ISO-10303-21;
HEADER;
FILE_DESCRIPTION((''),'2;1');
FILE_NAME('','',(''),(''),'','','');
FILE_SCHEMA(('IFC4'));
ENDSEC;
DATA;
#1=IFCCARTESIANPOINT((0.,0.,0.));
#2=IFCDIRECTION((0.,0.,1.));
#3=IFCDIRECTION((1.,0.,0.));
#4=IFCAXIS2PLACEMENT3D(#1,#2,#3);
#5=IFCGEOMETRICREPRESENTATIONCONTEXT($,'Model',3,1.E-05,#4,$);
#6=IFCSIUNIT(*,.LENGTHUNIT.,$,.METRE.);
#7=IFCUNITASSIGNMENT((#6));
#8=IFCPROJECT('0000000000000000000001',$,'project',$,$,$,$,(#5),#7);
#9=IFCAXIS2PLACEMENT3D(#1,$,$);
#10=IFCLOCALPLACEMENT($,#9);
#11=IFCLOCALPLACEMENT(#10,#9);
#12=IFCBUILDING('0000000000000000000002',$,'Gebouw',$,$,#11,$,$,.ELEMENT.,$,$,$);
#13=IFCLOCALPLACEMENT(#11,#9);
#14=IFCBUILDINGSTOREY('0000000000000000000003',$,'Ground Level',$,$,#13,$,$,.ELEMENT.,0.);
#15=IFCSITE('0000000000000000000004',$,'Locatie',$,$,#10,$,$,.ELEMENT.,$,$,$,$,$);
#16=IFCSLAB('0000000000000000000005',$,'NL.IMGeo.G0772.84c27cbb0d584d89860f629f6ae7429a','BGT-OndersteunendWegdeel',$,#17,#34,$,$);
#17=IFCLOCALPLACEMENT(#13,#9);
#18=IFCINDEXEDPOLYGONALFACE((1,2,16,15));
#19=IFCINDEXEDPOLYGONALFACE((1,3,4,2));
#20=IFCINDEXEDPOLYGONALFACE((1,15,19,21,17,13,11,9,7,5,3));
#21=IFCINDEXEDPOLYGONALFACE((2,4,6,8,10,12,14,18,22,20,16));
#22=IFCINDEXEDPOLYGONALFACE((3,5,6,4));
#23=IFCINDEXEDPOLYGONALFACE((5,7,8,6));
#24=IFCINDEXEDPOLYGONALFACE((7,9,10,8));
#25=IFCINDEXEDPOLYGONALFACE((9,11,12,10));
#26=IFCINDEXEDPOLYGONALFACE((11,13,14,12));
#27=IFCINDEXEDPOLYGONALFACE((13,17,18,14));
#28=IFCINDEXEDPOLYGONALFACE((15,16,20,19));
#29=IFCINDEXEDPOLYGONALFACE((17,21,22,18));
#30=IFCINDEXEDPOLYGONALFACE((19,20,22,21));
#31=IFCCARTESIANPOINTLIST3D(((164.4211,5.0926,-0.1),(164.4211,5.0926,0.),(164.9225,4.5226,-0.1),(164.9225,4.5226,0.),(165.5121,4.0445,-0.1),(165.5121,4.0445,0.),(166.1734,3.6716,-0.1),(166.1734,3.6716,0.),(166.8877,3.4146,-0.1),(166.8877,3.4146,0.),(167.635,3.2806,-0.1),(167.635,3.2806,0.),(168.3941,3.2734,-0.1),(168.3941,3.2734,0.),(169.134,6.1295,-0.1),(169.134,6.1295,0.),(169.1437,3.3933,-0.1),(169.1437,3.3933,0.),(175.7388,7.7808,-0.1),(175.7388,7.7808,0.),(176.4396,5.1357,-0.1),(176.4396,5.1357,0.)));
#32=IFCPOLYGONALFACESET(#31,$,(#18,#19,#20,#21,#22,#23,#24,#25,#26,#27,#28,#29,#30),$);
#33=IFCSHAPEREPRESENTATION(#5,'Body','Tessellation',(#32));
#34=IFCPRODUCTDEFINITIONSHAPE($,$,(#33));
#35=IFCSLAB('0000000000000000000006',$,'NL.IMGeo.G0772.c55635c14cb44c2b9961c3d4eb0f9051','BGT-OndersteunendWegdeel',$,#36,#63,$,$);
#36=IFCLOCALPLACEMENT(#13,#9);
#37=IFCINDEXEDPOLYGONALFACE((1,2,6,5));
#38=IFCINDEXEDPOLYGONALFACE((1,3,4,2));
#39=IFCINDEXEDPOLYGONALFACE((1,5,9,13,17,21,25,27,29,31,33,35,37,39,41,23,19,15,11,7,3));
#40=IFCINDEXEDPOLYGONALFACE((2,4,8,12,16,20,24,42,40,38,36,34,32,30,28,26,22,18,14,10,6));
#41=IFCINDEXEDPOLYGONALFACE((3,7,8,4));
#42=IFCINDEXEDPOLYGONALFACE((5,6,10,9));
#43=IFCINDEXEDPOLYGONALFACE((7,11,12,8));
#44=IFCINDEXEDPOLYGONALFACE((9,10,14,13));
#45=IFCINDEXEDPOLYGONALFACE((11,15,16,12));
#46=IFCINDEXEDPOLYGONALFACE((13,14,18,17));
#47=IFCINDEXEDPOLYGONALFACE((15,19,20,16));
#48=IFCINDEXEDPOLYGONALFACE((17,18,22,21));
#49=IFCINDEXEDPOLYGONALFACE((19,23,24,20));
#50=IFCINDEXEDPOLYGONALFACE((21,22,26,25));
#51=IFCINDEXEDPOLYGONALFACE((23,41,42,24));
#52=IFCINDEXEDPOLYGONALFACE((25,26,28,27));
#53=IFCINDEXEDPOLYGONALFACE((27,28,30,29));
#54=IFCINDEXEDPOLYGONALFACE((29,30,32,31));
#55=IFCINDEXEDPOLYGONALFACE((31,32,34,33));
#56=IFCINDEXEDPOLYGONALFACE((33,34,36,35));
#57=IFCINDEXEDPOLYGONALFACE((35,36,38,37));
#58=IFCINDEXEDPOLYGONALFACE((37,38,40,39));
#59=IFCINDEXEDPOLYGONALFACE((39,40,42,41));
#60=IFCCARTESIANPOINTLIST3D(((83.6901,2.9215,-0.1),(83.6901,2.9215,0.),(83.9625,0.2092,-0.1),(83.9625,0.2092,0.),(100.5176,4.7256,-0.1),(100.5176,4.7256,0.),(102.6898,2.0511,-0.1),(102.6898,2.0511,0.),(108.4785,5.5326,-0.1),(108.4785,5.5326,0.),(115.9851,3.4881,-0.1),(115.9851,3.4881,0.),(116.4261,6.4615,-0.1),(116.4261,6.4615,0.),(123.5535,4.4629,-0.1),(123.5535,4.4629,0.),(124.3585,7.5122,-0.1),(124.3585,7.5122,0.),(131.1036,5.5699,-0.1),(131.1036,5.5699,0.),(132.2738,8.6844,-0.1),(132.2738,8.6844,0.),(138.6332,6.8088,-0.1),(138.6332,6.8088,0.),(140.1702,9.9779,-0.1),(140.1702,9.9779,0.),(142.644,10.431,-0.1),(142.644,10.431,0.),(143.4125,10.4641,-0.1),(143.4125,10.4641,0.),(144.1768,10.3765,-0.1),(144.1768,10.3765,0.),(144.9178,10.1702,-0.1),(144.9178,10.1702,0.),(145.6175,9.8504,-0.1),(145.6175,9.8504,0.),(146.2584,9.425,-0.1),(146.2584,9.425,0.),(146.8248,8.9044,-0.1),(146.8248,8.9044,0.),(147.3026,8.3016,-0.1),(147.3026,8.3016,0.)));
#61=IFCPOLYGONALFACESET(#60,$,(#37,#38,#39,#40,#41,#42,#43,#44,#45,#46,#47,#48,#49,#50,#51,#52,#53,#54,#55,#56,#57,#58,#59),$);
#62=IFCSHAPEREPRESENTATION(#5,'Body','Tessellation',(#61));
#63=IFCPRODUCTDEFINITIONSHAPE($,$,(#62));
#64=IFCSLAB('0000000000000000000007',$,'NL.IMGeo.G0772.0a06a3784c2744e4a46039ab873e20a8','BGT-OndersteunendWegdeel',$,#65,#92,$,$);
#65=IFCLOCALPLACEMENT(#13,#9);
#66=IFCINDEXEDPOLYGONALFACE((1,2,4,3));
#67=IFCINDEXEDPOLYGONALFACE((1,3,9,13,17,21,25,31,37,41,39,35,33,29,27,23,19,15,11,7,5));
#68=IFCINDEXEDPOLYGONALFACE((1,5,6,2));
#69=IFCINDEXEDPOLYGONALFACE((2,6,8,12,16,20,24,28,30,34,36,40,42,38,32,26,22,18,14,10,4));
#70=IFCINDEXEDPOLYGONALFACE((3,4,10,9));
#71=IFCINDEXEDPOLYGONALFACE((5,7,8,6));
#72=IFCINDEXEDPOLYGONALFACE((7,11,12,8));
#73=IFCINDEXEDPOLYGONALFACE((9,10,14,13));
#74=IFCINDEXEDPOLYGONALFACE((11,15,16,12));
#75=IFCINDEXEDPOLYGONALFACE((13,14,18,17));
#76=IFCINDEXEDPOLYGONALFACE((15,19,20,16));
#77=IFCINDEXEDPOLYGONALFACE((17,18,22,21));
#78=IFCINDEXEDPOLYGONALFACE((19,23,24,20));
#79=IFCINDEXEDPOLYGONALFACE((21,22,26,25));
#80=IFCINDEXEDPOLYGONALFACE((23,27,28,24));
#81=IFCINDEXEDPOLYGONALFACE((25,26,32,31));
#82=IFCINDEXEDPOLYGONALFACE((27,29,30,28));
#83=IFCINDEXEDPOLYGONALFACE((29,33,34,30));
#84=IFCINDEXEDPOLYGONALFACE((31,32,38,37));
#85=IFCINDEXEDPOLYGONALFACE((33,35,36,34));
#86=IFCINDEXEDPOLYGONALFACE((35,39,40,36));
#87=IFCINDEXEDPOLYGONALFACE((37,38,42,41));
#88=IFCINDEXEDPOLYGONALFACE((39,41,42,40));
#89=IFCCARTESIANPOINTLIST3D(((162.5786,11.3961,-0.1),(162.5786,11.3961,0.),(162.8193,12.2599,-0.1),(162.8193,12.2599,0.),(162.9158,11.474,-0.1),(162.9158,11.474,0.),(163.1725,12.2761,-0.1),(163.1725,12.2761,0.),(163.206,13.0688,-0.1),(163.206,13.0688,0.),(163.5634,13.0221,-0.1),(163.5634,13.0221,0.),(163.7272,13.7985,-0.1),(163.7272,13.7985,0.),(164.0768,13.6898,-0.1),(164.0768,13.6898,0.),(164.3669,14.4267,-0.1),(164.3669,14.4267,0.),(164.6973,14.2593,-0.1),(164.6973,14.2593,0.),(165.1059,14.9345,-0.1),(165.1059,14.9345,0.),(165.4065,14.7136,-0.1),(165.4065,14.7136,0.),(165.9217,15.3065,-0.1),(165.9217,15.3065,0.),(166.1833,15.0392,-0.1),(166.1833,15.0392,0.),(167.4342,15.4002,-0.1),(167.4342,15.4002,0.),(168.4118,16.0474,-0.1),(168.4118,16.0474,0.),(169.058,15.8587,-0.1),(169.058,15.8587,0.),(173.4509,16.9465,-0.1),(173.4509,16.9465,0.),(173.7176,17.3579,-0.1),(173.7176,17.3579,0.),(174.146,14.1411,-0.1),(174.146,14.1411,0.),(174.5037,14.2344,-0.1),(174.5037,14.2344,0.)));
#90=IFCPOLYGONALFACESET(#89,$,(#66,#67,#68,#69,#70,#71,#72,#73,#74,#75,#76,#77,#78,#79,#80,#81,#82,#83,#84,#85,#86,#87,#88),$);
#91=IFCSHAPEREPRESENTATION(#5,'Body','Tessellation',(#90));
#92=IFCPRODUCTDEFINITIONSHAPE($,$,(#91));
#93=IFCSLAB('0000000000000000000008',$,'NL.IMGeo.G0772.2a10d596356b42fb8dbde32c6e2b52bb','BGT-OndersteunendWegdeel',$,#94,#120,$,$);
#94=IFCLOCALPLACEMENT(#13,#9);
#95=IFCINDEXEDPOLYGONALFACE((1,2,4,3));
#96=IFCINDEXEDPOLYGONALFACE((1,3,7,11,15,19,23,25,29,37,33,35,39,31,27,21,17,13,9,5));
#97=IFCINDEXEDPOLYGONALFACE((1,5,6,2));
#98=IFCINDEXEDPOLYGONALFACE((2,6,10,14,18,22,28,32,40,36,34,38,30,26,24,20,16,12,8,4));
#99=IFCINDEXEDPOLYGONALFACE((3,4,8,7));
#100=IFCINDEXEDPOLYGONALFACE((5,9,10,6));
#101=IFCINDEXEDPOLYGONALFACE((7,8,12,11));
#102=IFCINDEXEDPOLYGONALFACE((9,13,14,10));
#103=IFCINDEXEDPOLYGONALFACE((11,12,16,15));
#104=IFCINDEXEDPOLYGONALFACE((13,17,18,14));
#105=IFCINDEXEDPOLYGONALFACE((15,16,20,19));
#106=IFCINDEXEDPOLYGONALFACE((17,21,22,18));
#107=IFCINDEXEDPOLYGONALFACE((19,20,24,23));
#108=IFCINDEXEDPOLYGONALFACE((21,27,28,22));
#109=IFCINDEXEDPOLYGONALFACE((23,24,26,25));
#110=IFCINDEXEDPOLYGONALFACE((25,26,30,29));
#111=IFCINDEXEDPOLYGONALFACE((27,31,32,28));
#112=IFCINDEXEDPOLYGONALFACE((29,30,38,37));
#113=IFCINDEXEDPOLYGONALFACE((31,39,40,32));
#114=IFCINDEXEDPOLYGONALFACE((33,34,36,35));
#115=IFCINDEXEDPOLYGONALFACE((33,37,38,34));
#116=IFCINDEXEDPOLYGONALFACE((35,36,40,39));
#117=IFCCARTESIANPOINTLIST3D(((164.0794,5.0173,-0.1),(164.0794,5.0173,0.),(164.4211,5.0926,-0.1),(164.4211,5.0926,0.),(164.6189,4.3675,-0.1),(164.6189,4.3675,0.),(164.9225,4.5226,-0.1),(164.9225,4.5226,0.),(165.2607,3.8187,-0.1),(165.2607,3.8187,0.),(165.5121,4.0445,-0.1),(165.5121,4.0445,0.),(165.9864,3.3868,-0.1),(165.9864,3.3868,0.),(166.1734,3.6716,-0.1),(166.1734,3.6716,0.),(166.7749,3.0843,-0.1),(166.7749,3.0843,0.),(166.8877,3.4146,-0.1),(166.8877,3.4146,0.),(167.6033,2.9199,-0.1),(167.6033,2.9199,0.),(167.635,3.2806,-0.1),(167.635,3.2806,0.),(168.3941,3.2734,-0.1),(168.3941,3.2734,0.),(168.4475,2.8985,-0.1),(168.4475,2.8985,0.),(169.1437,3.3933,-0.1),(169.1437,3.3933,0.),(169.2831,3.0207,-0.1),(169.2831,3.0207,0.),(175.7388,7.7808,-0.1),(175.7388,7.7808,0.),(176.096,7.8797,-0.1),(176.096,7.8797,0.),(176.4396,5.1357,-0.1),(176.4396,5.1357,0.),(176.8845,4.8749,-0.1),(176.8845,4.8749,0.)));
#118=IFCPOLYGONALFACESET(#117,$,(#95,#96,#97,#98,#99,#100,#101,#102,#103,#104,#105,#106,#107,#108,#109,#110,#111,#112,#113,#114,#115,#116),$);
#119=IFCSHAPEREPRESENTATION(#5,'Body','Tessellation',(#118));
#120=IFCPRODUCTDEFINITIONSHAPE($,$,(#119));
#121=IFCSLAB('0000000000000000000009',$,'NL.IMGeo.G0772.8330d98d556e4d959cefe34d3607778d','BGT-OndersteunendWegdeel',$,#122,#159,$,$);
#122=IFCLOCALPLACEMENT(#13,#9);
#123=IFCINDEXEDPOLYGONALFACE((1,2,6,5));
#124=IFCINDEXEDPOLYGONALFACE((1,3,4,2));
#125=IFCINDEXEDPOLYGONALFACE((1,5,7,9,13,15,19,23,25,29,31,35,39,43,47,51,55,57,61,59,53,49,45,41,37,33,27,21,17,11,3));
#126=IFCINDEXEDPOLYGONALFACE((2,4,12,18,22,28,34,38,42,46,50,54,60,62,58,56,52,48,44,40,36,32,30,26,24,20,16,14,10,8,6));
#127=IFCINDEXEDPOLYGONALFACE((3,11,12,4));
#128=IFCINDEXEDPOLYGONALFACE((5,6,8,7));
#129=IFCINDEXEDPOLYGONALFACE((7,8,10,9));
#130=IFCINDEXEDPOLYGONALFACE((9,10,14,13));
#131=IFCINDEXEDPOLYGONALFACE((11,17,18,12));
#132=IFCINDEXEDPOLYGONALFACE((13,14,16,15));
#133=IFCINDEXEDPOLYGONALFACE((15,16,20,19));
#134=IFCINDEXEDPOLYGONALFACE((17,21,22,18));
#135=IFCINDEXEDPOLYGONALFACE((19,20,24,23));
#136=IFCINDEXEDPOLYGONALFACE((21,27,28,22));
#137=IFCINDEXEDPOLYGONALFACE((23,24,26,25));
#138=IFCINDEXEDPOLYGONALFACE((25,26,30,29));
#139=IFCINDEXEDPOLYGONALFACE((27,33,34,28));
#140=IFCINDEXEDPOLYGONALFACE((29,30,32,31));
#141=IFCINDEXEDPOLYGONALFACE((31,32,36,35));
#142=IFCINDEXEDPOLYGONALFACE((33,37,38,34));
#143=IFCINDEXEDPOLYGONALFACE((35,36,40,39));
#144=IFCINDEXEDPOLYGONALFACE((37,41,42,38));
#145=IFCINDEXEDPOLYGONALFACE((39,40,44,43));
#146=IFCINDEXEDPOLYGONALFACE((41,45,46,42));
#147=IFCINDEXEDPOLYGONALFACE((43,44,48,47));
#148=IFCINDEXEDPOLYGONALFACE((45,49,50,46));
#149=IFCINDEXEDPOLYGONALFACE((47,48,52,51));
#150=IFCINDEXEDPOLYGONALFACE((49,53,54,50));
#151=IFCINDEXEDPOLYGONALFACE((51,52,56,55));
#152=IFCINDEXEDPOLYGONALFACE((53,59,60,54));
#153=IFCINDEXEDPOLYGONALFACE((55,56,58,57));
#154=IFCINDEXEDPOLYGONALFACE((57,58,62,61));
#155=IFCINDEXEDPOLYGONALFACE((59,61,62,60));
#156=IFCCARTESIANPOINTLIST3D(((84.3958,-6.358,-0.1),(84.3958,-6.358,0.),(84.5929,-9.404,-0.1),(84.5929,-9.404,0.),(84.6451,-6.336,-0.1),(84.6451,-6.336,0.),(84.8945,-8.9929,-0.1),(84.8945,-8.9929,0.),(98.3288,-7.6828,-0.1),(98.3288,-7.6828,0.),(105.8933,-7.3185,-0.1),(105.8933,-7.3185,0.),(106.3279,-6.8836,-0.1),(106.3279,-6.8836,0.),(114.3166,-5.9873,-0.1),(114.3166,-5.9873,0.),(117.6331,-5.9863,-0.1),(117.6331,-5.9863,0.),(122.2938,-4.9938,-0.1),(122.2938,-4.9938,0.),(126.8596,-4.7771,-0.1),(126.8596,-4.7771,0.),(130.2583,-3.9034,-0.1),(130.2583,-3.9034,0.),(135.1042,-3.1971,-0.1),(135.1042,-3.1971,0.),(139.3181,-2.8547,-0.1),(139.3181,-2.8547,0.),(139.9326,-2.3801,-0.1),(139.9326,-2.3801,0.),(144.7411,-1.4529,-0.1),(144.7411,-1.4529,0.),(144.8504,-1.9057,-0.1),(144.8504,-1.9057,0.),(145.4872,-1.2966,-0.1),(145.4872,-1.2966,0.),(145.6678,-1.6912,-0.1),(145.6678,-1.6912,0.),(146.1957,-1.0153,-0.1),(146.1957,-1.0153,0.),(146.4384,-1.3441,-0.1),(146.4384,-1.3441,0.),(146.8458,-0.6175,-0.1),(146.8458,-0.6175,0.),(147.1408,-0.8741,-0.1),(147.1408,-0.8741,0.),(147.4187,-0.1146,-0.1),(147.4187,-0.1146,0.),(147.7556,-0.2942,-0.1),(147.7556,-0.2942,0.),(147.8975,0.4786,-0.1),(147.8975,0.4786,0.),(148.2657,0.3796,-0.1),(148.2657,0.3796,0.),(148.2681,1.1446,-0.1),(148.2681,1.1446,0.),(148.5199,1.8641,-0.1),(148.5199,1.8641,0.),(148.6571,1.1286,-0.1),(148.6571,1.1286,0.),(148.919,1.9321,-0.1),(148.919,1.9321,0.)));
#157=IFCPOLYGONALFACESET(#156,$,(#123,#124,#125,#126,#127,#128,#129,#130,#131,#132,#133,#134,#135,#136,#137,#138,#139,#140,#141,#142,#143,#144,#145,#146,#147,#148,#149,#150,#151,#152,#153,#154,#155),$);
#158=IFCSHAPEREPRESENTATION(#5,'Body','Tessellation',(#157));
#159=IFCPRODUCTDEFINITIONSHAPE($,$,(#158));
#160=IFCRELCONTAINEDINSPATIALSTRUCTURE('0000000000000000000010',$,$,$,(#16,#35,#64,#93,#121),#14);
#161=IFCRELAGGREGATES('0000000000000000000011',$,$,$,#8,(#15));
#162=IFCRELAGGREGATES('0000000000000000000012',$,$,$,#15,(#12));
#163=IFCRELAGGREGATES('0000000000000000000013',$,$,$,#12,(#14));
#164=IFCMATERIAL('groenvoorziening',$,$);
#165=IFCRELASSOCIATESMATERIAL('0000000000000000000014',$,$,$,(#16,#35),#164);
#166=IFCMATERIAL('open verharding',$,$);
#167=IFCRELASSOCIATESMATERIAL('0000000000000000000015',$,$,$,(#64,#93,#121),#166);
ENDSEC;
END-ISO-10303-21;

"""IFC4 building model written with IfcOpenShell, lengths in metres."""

from ifc_helpers import new_model, si_unit, frame, origin, origin_with_axes, place, context, project, spatial, polyline, outline, extrude, material, element, save


model = new_model("IFC4")

# Units and contexts
model_context = context("Model", 3, precision=1e-05, world=origin_with_axes())
ifc_project = project(units=[si_unit("LENGTHUNIT", "METRE")], contexts=[model_context])

# Site, building, storey
site_placement = place(None, origin())
site = spatial("IfcSite", under=ifc_project, at=site_placement, Name="Locatie", CompositionType="ELEMENT")
building_placement = place(site_placement, origin())
building = spatial("IfcBuilding", under=site, at=building_placement, Name="Gebouw", CompositionType="ELEMENT")
storey_placement = place(building_placement, origin())
storey = spatial("IfcBuildingStorey", under=building, at=storey_placement, Name="Ground Level", CompositionType="ELEMENT", Elevation=0.0)

# Slabs
ifc_material_1 = material(Name="open verharding")
ifc_material_2 = material(Name="groenvoorziening")
slab_1_placement = place(storey_placement, origin())
element("IfcSlab", 1, at=slab_1_placement, inside=storey, material=ifc_material_2, Name="NL.IMGeo.G0772.84c27cbb0d584d89860f629f6ae7429a", Description="BGT-OndersteunendWegdeel", context=model_context, shape_type="SweptSolid", body=[
    extrude(outline(polyline([(175.7388, 7.7808), (176.4396, 5.1357), (169.1437, 3.3933), (168.3941, 3.2734), (167.635, 3.2806), (166.8877, 3.4146), (166.1734, 3.6716), (165.5121, 4.0445), (164.9225, 4.5226), (164.4211, 5.0926), (169.134, 6.1295), (175.7388, 7.7808)])), frame((0.0, 0.0, -0.1), z_axis=(0.0, 0.0, 1.0), x_axis=(1.0, 0.0, 0.0)), (0.0, 0.0, 1.0), 0.1),
])
slab_2_placement = place(storey_placement, origin())
element("IfcSlab", 2, at=slab_2_placement, inside=storey, material=ifc_material_2, Name="NL.IMGeo.G0772.c55635c14cb44c2b9961c3d4eb0f9051", Description="BGT-OndersteunendWegdeel", context=model_context, shape_type="SweptSolid", body=[
    extrude(outline(polyline([(83.6901, 2.9215), (100.5176, 4.7256), (108.4785, 5.5326), (116.4261, 6.4615), (124.3585, 7.5122), (132.2738, 8.6844), (140.1702, 9.9779), (142.644, 10.431), (143.4125, 10.4641), (144.1768, 10.3765), (144.9178, 10.1702), (145.6175, 9.8504), (146.2584, 9.425), (146.8248, 8.9044), (147.3026, 8.3016), (138.6332, 6.8088), (131.1036, 5.5699), (123.5535, 4.4629), (115.9851, 3.4881), (102.6898, 2.0511), (83.9625, 0.2092), (83.6901, 2.9215)])), frame((0.0, 0.0, -0.1), z_axis=(0.0, 0.0, 1.0), x_axis=(1.0, 0.0, 0.0)), (0.0, 0.0, 1.0), 0.1),
])
slab_3_placement = place(storey_placement, origin())
element("IfcSlab", 3, at=slab_3_placement, inside=storey, material=ifc_material_1, Name="NL.IMGeo.G0772.0a06a3784c2744e4a46039ab873e20a8", Description="BGT-OndersteunendWegdeel", context=model_context, shape_type="SweptSolid", body=[
    extrude(outline(polyline([(173.7176, 17.3579), (174.5037, 14.2344), (174.146, 14.1411), (173.4509, 16.9465), (169.058, 15.8587), (167.4342, 15.4002), (166.1833, 15.0392), (165.4065, 14.7136), (164.6973, 14.2593), (164.0768, 13.6898), (163.5634, 13.0221), (163.1725, 12.2761), (162.9158, 11.474), (162.5786, 11.3961), (162.8193, 12.2599), (163.206, 13.0688), (163.7272, 13.7985), (164.3669, 14.4267), (165.1059, 14.9345), (165.9217, 15.3065), (168.4118, 16.0474), (173.7176, 17.3579)])), frame((0.0, 0.0, -0.1), z_axis=(0.0, 0.0, 1.0), x_axis=(1.0, 0.0, 0.0)), (0.0, 0.0, 1.0), 0.1),
])
slab_4_placement = place(storey_placement, origin())
element("IfcSlab", 4, at=slab_4_placement, inside=storey, material=ifc_material_1, Name="NL.IMGeo.G0772.2a10d596356b42fb8dbde32c6e2b52bb", Description="BGT-OndersteunendWegdeel", context=model_context, shape_type="SweptSolid", body=[
    extrude(outline(polyline([(164.9225, 4.5226), (165.5121, 4.0445), (166.1734, 3.6716), (166.8877, 3.4146), (167.635, 3.2806), (168.3941, 3.2734), (169.1437, 3.3933), (176.4396, 5.1357), (175.7388, 7.7808), (176.096, 7.8797), (176.8845, 4.8749), (169.2831, 3.0207), (168.4475, 2.8985), (167.6033, 2.9199), (166.7749, 3.0843), (165.9864, 3.3868), (165.2607, 3.8187), (164.6189, 4.3675), (164.0794, 5.0173), (164.4211, 5.0926), (164.9225, 4.5226)])), frame((0.0, 0.0, -0.1), z_axis=(0.0, 0.0, 1.0), x_axis=(1.0, 0.0, 0.0)), (0.0, 0.0, 1.0), 0.1),
])
slab_5_placement = place(storey_placement, origin())
element("IfcSlab", 5, at=slab_5_placement, inside=storey, material=ifc_material_1, Name="NL.IMGeo.G0772.8330d98d556e4d959cefe34d3607778d", Description="BGT-OndersteunendWegdeel", context=model_context, shape_type="SweptSolid", body=[
    extrude(outline(polyline([(84.8945, -8.9929), (98.3288, -7.6828), (106.3279, -6.8836), (114.3166, -5.9873), (122.2938, -4.9938), (130.2583, -3.9034), (135.1042, -3.1971), (139.9326, -2.3801), (144.7411, -1.4529), (145.4872, -1.2966), (146.1957, -1.0153), (146.8458, -0.6175), (147.4187, -0.1146), (147.8975, 0.4786), (148.2681, 1.1446), (148.5199, 1.8641), (148.919, 1.9321), (148.6571, 1.1286), (148.2657, 0.3796), (147.7556, -0.2942), (147.1408, -0.8741), (146.4384, -1.3441), (145.6678, -1.6912), (144.8504, -1.9057), (139.3181, -2.8547), (126.8596, -4.7771), (117.6331, -5.9863), (105.8933, -7.3185), (84.5929, -9.404), (84.3958, -6.358), (84.6451, -6.336), (84.8945, -8.9929)])), frame((0.0, 0.0, -0.1), z_axis=(0.0, 0.0, 1.0), x_axis=(1.0, 0.0, 0.0)), (0.0, 0.0, 1.0), 0.1),
])

save(model, "model.ifc")
